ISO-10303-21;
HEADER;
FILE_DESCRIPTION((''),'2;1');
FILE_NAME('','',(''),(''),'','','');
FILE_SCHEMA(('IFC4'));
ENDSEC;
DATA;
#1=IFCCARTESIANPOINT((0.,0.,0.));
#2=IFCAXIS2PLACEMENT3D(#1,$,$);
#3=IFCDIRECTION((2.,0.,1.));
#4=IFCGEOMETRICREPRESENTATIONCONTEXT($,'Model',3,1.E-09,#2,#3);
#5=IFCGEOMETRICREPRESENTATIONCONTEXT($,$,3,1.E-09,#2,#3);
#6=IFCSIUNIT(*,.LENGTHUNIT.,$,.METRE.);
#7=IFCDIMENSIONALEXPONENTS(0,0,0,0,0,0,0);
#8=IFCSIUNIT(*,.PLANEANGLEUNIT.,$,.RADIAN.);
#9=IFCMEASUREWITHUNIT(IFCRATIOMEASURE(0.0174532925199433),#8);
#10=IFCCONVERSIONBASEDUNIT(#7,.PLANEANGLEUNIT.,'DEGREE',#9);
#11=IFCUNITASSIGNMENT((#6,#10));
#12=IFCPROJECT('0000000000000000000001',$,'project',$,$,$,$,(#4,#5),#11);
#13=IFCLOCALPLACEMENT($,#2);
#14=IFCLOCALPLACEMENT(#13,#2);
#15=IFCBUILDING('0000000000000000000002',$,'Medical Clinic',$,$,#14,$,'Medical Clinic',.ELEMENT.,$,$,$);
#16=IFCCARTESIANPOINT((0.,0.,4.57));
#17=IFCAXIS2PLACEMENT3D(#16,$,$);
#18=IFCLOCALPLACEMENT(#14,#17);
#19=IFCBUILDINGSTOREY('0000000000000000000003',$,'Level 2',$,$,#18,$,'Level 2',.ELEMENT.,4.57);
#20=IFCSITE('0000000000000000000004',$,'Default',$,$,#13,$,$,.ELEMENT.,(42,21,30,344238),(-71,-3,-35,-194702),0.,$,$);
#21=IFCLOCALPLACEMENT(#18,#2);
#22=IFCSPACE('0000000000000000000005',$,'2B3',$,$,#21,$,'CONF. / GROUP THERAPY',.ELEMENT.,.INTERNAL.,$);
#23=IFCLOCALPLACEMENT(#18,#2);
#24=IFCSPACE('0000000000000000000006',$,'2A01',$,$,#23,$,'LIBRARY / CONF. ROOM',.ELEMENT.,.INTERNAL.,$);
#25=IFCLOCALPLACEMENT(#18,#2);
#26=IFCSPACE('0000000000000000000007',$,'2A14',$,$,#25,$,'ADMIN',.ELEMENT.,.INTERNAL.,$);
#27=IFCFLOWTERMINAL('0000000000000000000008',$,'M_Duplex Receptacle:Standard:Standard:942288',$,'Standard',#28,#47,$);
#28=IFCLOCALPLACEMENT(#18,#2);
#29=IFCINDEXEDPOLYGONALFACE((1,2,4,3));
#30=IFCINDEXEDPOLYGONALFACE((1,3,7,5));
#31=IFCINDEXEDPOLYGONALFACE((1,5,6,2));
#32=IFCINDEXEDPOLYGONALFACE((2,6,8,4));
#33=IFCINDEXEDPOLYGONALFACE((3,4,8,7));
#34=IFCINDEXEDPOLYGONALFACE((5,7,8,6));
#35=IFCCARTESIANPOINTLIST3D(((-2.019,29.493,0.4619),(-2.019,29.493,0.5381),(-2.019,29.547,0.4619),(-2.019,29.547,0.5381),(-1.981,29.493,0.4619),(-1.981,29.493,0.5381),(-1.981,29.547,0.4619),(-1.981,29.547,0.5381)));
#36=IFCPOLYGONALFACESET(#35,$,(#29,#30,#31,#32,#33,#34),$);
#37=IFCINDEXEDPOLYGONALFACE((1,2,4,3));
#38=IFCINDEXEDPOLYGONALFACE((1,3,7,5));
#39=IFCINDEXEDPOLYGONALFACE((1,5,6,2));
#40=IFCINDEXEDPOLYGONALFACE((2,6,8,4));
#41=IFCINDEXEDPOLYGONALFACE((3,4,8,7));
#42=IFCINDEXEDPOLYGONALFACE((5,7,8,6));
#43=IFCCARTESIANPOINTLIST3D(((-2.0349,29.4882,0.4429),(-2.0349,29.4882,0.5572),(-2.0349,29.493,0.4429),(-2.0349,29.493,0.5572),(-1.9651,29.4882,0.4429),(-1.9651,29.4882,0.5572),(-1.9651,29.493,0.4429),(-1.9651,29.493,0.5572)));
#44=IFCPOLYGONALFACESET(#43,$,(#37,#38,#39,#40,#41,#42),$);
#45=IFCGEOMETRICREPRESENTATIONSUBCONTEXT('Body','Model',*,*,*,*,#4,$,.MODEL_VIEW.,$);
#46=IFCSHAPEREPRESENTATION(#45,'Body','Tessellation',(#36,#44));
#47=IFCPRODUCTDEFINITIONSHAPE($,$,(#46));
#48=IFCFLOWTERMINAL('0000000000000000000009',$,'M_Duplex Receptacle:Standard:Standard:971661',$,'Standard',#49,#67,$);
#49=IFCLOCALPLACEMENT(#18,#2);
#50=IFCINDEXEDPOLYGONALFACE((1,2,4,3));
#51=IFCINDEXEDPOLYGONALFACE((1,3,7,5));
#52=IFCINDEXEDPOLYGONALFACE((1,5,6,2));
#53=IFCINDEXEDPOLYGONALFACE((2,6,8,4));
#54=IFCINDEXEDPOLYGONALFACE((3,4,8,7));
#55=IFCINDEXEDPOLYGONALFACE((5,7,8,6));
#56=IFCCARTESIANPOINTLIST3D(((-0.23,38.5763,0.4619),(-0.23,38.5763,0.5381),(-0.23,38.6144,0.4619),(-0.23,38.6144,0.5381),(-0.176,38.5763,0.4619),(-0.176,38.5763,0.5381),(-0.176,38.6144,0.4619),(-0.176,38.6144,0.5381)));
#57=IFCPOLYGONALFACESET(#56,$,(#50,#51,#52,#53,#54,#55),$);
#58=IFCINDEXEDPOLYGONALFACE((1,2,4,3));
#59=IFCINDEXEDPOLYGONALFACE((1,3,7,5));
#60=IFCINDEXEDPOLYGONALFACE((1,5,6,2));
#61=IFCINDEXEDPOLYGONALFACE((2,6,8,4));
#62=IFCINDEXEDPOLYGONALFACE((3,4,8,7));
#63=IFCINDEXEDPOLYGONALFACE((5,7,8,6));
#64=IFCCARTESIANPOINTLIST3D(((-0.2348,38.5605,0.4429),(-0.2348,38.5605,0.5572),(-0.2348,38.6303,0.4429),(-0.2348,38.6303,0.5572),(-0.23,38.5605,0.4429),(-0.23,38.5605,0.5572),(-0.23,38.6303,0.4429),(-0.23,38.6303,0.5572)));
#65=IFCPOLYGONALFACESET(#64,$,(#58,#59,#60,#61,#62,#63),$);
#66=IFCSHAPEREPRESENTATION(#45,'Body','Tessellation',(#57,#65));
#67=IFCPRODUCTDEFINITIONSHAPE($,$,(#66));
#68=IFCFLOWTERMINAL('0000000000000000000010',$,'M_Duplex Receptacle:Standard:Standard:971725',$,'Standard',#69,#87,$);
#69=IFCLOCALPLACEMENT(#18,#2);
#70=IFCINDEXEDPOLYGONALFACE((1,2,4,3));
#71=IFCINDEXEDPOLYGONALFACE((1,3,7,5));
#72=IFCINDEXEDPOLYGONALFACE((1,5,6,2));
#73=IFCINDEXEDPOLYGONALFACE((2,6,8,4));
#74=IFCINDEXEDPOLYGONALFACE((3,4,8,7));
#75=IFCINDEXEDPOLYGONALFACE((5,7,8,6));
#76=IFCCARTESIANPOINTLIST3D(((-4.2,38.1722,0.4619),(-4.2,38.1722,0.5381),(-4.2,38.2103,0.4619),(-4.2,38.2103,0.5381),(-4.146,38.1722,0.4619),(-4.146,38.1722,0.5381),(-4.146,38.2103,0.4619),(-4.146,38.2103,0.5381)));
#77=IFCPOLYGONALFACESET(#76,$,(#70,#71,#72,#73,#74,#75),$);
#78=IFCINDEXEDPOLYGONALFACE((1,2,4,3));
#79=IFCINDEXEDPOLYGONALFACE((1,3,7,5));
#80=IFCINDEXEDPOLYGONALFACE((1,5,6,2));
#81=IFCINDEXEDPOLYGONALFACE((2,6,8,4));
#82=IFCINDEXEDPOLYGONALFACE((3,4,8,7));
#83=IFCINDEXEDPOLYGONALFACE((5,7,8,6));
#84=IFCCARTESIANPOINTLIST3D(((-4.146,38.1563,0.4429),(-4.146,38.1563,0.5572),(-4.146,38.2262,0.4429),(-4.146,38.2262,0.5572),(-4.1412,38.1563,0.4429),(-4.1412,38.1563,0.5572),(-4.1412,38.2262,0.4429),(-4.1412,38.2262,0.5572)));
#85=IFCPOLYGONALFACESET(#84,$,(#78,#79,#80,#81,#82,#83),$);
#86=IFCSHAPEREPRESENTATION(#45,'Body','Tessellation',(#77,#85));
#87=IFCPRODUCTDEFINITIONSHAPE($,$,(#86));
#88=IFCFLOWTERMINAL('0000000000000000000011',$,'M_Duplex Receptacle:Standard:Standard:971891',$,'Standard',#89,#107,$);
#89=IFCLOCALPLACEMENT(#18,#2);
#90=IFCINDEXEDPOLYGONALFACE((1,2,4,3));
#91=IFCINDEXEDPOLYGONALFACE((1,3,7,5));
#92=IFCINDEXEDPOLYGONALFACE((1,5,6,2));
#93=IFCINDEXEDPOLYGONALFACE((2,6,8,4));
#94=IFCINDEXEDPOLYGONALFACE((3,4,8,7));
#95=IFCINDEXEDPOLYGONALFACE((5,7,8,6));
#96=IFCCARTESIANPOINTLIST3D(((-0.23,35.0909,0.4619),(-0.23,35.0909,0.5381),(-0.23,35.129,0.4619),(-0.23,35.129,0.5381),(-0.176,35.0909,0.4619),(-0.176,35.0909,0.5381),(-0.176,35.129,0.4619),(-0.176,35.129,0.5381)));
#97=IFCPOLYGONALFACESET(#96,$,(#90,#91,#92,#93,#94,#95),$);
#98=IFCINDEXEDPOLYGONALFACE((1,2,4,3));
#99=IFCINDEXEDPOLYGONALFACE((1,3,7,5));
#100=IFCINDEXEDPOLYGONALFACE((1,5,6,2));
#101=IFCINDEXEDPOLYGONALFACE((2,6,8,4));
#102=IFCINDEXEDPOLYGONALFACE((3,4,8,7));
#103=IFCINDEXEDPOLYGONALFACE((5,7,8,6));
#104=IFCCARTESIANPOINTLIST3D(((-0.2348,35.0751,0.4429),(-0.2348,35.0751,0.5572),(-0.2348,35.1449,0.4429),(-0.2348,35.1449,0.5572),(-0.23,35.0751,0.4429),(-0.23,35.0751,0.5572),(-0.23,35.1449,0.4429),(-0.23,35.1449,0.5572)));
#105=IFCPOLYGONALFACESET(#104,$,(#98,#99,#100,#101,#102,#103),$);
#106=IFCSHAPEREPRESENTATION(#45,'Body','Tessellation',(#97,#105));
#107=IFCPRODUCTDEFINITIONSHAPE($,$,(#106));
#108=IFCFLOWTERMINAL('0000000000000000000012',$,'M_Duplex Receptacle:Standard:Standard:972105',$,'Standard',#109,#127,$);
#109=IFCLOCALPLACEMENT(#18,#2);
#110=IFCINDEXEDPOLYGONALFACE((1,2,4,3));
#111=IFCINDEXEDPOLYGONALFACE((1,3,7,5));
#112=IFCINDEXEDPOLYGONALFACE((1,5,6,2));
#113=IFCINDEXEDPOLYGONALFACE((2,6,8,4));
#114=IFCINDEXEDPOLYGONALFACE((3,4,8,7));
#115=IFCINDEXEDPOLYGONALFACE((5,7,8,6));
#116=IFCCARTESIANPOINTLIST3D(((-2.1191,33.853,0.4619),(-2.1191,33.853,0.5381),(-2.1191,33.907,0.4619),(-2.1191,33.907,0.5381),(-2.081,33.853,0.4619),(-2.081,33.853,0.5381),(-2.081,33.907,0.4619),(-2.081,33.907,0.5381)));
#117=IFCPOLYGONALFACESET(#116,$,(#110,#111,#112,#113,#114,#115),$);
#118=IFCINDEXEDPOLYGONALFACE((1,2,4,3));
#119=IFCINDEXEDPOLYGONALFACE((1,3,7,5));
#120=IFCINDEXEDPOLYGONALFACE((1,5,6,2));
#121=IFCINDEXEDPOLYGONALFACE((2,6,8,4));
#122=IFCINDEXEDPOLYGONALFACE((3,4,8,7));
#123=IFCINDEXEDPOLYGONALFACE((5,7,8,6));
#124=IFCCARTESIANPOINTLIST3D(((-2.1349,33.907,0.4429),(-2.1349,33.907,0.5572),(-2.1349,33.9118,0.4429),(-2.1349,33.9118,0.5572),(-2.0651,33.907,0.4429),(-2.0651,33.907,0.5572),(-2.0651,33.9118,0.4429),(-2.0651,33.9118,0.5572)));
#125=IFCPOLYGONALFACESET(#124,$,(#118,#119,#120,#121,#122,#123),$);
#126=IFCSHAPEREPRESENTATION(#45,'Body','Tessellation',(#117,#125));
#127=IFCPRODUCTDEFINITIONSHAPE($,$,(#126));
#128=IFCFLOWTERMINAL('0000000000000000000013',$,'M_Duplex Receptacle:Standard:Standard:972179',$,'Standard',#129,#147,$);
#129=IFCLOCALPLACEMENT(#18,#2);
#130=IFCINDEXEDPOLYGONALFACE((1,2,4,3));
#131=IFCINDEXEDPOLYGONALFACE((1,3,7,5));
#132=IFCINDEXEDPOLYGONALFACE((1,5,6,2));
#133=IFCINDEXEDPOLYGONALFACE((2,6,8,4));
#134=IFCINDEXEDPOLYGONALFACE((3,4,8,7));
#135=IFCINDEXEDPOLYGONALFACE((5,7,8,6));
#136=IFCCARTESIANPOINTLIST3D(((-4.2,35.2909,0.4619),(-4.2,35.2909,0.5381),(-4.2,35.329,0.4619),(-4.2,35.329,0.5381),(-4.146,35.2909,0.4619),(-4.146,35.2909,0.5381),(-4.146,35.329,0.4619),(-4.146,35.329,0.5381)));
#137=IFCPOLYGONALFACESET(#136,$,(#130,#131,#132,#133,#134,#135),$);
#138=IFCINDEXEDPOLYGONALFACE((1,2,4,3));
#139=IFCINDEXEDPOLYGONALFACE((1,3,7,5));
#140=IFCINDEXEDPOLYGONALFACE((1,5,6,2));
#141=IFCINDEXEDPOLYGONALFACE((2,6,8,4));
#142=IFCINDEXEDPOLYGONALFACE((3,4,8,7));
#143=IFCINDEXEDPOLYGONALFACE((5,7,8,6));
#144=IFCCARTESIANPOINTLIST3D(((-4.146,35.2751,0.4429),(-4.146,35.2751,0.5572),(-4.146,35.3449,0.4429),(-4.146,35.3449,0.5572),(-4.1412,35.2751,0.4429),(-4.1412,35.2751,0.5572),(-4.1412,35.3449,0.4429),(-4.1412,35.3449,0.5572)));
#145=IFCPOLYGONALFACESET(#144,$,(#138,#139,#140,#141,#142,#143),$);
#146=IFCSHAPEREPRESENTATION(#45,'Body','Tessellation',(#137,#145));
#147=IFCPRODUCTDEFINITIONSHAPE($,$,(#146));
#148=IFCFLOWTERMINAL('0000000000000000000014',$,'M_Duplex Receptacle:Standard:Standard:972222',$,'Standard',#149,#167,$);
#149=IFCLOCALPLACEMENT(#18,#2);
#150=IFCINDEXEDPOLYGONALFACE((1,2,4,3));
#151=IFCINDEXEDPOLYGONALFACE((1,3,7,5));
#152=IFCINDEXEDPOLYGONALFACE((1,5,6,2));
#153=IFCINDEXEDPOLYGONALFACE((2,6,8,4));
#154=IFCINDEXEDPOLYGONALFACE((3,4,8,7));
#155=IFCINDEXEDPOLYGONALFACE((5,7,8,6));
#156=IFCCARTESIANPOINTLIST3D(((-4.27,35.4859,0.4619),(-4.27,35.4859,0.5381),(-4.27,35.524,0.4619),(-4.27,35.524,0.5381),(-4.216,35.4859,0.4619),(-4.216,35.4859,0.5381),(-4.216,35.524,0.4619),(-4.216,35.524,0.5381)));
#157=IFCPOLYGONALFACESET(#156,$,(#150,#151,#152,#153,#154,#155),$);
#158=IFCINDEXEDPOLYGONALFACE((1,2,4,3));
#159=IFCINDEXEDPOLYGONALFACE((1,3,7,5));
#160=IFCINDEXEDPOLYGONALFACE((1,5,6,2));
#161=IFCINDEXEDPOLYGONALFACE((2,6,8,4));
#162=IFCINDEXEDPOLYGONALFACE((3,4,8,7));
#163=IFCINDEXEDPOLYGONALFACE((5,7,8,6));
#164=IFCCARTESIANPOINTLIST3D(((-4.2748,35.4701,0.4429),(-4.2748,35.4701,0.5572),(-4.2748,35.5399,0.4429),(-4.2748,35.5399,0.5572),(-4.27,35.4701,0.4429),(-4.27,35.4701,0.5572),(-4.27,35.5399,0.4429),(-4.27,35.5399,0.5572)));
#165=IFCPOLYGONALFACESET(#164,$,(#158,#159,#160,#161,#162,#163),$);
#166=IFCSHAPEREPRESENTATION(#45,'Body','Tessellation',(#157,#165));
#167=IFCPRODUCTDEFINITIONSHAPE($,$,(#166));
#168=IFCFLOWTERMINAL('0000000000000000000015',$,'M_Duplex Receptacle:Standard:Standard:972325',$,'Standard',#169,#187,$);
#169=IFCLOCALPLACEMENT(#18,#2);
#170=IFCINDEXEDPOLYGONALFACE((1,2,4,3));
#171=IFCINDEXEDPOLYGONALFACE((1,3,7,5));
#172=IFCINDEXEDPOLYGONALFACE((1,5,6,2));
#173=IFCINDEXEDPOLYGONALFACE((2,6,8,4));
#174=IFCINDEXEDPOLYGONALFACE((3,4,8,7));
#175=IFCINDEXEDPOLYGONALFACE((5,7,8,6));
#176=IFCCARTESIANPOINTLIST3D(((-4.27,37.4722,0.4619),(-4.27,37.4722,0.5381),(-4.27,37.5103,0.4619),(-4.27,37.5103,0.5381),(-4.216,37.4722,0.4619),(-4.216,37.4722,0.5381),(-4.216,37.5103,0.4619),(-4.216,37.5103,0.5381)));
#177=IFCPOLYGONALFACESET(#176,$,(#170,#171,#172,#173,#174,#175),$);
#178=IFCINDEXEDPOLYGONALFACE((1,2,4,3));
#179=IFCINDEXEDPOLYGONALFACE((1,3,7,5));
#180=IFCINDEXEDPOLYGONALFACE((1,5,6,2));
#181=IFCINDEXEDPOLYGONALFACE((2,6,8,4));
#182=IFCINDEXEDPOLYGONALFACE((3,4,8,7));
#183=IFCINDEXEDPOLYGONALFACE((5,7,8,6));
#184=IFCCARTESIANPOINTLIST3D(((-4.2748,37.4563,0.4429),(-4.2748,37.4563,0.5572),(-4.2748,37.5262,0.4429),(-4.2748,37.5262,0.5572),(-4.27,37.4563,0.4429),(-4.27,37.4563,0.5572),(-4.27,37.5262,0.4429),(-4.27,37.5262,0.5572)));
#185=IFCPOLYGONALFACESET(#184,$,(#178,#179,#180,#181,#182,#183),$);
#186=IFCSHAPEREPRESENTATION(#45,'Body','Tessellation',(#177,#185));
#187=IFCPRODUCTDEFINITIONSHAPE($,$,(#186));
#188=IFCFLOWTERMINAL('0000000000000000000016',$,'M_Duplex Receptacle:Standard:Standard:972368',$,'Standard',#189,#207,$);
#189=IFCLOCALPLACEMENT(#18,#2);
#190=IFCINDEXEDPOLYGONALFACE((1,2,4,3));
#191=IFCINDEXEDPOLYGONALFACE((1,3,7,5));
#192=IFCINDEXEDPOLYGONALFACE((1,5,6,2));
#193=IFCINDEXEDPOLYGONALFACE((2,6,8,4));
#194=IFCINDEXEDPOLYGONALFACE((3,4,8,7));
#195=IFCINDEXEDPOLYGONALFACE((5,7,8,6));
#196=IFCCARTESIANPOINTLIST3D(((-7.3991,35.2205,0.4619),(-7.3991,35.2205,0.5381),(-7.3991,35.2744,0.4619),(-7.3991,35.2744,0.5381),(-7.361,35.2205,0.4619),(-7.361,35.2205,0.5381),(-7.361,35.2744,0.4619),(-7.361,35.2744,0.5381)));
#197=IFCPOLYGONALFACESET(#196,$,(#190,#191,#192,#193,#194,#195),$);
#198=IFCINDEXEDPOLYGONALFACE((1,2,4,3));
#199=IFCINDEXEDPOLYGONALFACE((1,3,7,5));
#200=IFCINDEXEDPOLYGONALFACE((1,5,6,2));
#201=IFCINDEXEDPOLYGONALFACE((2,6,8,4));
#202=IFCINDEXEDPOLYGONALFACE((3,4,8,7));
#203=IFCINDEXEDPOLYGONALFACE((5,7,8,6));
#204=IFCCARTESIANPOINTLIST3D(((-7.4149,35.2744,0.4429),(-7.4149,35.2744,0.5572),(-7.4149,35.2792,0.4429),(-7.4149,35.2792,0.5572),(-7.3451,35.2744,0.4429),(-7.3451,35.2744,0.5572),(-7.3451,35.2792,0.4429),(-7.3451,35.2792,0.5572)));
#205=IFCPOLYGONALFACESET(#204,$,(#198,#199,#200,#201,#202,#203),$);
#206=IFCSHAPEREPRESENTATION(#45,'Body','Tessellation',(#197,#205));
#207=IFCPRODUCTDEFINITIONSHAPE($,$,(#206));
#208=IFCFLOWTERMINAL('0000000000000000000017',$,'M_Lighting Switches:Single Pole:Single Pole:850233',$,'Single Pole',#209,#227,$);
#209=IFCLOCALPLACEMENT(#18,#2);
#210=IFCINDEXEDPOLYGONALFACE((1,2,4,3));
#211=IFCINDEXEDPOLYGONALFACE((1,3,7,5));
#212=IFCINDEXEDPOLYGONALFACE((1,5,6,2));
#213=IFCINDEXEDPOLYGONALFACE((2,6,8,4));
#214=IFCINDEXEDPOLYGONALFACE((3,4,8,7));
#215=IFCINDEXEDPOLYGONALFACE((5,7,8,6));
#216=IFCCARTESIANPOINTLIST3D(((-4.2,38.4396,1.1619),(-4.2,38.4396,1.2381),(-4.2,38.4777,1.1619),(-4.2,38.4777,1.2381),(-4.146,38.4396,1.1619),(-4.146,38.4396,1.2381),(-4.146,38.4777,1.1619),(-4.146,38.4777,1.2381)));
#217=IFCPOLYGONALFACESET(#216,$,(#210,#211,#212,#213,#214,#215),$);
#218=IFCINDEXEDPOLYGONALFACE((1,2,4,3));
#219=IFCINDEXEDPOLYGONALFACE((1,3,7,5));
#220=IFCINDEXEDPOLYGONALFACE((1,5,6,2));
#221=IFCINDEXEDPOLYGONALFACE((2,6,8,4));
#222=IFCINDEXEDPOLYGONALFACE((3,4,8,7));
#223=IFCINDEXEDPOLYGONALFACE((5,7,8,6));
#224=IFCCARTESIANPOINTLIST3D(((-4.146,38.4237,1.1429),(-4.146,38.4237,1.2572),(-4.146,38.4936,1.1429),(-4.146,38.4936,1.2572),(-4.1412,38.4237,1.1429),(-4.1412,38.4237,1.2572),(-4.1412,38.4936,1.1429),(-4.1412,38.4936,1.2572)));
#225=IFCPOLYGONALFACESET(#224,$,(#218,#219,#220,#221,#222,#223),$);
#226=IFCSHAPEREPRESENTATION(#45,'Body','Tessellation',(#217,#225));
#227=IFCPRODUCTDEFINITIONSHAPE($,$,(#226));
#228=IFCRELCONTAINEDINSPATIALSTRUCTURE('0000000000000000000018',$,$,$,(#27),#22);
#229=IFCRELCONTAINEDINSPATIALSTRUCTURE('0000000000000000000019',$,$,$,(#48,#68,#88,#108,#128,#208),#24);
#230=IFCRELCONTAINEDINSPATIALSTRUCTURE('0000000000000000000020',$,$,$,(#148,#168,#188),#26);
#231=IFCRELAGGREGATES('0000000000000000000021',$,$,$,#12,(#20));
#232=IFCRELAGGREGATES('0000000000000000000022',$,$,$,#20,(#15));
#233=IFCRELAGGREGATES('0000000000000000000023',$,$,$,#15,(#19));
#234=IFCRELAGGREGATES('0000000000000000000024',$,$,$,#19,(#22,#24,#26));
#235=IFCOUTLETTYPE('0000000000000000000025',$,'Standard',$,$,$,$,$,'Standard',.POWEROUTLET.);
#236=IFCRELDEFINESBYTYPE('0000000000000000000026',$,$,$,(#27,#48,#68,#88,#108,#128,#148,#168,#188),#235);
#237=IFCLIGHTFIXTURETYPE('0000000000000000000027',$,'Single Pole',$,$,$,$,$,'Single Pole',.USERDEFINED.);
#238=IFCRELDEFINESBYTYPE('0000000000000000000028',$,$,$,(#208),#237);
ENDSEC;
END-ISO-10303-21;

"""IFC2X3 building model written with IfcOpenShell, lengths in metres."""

from ifc_helpers import new_model, entity, si_unit, converted_unit, direction, frame, frame_2d, origin, origin_2d_with_axis, place, context, subcontext, project, spatial, rectangle, extrude, source, transform, mapped, type_object, type_shapes, element, save


model = new_model("IFC2X3")

# Units and contexts
model_context = context("Model", 3, precision=1e-09, world=origin(), true_north=direction((2.0, 0.0, 1.0)))
context_of_model = context(None, 3, precision=1e-09, world=origin(), true_north=direction((2.0, 0.0, 1.0)))
body_context = subcontext(model_context, "Body", "Model", "MODEL_VIEW")
ifc_project = project(units=[si_unit("LENGTHUNIT", "METRE"), converted_unit("PLANEANGLEUNIT", "DEGREE", entity("IfcRatioMeasure", 0.0174532925199433), si_unit("PLANEANGLEUNIT", "RADIAN"), dimensions=[0, 0, 0, 0, 0, 0, 0])], contexts=[model_context, context_of_model])

# Site, building, storey, space
site_placement = place(None, origin())
site = spatial("IfcSite", under=ifc_project, at=site_placement, Name="Default", CompositionType="ELEMENT", RefLatitude=(42, 21, 30, 344238), RefLongitude=(-71, -3, -35, -194702), RefElevation=0.0)
building_placement = place(site_placement, origin())
building = spatial("IfcBuilding", under=site, at=building_placement, Name="Medical Clinic", LongName="Medical Clinic", CompositionType="ELEMENT")
storey_placement = place(building_placement, frame((0.0, 0.0, 4.57)))
storey = spatial("IfcBuildingStorey", under=building, at=storey_placement, Name="Level 2", LongName="Level 2", CompositionType="ELEMENT", Elevation=4.57)
space_1_placement = place(storey_placement, origin())
space_1 = spatial("IfcSpace", under=storey, at=space_1_placement, Name="2B3", LongName="CONF. / GROUP THERAPY", CompositionType="ELEMENT", InteriorOrExteriorSpace="INTERNAL")

# Flow terminal
outlet_type = type_object("IfcOutletType", Name="Standard", ElementType="Standard", PredefinedType="POWEROUTLET")
shared_shape_1 = source(origin(), body_context, "Body", "SweptSolid", [
    extrude(rectangle(XDim=0.0381, YDim=0.0762, at=origin_2d_with_axis()), frame((0.0, 0.0, -0.054), z_axis=(0.0, 0.0, 1.0), x_axis=(-1.0, 0.0, 0.0)), (0.0, 0.0, 1.0), 0.054),
    extrude(rectangle(XDim=0.0698, YDim=0.1143, at=frame_2d((0.0, 0.0), x_axis=(1.0, 0.0))), frame((0.0, 0.0, 0.0), z_axis=(0.0, 0.0, 1.0), x_axis=(-1.0, 0.0, 0.0)), (0.0, 0.0, 1.0), 0.0048),
])
type_shapes(outlet_type, [shared_shape_1])
flow_terminal_1_placement = place(space_1_placement, frame((-2.0, 29.493, 0.5), z_axis=(0.0, -1.0, 0.0), x_axis=(1.0, 0.0, 0.0)))
element("IfcFlowTerminal", 1, at=flow_terminal_1_placement, inside=space_1, type_object=outlet_type, Name="M_Duplex Receptacle:Standard:Standard:942288", ObjectType="Standard", context=body_context, shape_type="MappedRepresentation", body=[
    mapped(shared_shape_1, transform((0.0, 0.0, 0.0), scale=1.0)),
])

# Shared definitions
space_2_placement = place(storey_placement, origin())
space_2 = spatial("IfcSpace", under=storey, at=space_2_placement, Name="2A01", LongName="LIBRARY / CONF. ROOM", CompositionType="ELEMENT", InteriorOrExteriorSpace="INTERNAL")

# Flow terminals
for number, where, z_axis, x_axis, name in (
    (2, (-0.23, 38.5954, 0.5), (-1.0, 0.0, 0.0), (0.0, -1.0, 0.0), "M_Duplex Receptacle:Standard:Standard:971661"),
    (3, (-4.146, 38.1912, 0.5), (1.0, 0.0, 0.0), (0.0, 1.0, 0.0), "M_Duplex Receptacle:Standard:Standard:971725"),
    (4, (-0.23, 35.11, 0.5), (-1.0, 0.0, 0.0), (0.0, -1.0, 0.0), "M_Duplex Receptacle:Standard:Standard:971891"),
    (5, (-2.1, 33.907, 0.5), (0.0, 1.0, 0.0), (-1.0, 0.0, 0.0), "M_Duplex Receptacle:Standard:Standard:972105"),
    (6, (-4.146, 35.31, 0.5), (1.0, 0.0, 0.0), (0.0, 1.0, 0.0), "M_Duplex Receptacle:Standard:Standard:972179"),
):
    element("IfcFlowTerminal", number, at=place(space_2_placement, frame(where, z_axis=z_axis, x_axis=x_axis)), inside=space_2, type_object=outlet_type, Name=name, ObjectType="Standard", context=body_context, shape_type="MappedRepresentation", body=[
        mapped(shared_shape_1, transform((0.0, 0.0, 0.0), scale=1.0)),
    ])

# Shared definitions
space_3_placement = place(storey_placement, origin())
space_3 = spatial("IfcSpace", under=storey, at=space_3_placement, Name="2A14", LongName="ADMIN", CompositionType="ELEMENT", InteriorOrExteriorSpace="INTERNAL")

# Flow terminals
for number, where, z_axis, x_axis, name in (
    (7, (-4.27, 35.505, 0.5), (-1.0, 0.0, 0.0), (0.0, -1.0, 0.0), "M_Duplex Receptacle:Standard:Standard:972222"),
    (8, (-4.27, 37.4912, 0.5), (-1.0, 0.0, 0.0), (0.0, -1.0, 0.0), "M_Duplex Receptacle:Standard:Standard:972325"),
    (9, (-7.38, 35.2744, 0.5), (0.0, 1.0, 0.0), (-1.0, 0.0, 0.0), "M_Duplex Receptacle:Standard:Standard:972368"),
):
    element("IfcFlowTerminal", number, at=place(space_3_placement, frame(where, z_axis=z_axis, x_axis=x_axis)), inside=space_3, type_object=outlet_type, Name=name, ObjectType="Standard", context=body_context, shape_type="MappedRepresentation", body=[
        mapped(shared_shape_1, transform((0.0, 0.0, 0.0), scale=1.0)),
    ])
light_fixture_type_1 = type_object("IfcLightFixtureType", Name="Single Pole", ElementType="Single Pole", PredefinedType="USERDEFINED")
shared_shape_2 = source(origin(), body_context, "Body", "SweptSolid", [
    extrude(rectangle(XDim=0.0381, YDim=0.0762, at=origin_2d_with_axis()), frame((0.0, 0.0, -0.054), z_axis=(0.0, 0.0, 1.0), x_axis=(-1.0, 0.0, 0.0)), (0.0, 0.0, 1.0), 0.054),
    extrude(rectangle(XDim=0.0698, YDim=0.1143, at=frame_2d((0.0, 0.0), x_axis=(1.0, 0.0))), frame((0.0, 0.0, 0.0), z_axis=(0.0, 0.0, 1.0), x_axis=(-1.0, 0.0, 0.0)), (0.0, 0.0, 1.0), 0.0048),
])
type_shapes(light_fixture_type_1, [shared_shape_2])
for number, where, z_axis, x_axis, name in (
    (10, (-4.146, 38.4586, 1.2), (1.0, 0.0, 0.0), (0.0, 1.0, 0.0), "M_Lighting Switches:Single Pole:Single Pole:850233"),
):
    element("IfcFlowTerminal", number, at=place(space_2_placement, frame(where, z_axis=z_axis, x_axis=x_axis)), inside=space_2, type_object=light_fixture_type_1, Name=name, ObjectType="Single Pole", context=body_context, shape_type="MappedRepresentation", body=[
        mapped(shared_shape_2, transform((0.0, 0.0, 0.0), scale=1.0)),
    ])

save(model, "model.ifc")
